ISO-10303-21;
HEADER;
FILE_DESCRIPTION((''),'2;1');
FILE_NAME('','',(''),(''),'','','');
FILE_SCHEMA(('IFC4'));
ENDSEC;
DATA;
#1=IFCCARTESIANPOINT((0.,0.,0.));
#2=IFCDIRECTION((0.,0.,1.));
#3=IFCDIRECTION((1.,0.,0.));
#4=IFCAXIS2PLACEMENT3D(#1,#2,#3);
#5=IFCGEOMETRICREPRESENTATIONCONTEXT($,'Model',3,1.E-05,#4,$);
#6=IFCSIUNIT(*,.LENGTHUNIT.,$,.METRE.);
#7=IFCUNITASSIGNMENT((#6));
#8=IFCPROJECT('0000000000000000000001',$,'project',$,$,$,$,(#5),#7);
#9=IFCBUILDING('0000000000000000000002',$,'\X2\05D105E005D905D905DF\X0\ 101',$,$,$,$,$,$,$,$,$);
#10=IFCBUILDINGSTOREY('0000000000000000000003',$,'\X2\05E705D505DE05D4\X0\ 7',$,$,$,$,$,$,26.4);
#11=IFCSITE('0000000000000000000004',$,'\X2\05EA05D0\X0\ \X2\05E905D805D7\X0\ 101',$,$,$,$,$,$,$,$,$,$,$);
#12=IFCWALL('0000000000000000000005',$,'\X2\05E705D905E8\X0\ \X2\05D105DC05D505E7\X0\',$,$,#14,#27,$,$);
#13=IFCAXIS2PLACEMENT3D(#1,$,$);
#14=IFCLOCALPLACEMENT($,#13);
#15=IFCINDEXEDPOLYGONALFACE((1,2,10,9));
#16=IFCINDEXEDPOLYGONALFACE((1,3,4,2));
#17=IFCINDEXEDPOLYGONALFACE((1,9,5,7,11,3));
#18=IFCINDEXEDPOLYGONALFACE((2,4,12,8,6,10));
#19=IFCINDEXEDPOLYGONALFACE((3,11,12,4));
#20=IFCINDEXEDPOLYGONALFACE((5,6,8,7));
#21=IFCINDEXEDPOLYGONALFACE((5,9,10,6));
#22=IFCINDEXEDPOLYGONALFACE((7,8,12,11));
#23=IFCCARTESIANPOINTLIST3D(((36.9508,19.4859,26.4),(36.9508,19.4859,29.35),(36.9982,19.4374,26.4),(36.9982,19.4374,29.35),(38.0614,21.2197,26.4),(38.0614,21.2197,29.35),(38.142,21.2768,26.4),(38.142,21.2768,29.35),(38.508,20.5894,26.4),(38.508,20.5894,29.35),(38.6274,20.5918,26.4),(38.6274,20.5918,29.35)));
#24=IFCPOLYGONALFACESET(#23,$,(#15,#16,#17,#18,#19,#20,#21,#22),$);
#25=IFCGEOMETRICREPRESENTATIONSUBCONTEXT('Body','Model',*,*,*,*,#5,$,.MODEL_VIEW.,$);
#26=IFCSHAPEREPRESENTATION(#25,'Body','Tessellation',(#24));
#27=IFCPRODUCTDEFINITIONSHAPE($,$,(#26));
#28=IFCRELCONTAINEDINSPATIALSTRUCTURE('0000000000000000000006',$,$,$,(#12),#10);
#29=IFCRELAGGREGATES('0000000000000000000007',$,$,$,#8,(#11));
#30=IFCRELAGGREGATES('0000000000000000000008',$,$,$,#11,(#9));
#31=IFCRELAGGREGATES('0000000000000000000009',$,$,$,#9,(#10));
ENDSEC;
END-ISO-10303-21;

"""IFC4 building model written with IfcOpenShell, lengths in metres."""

from ifc_helpers import new_model, si_unit, frame, origin_with_axes, context, subcontext, project, spatial, polyline, outline, extrude, element, save


model = new_model("IFC4")

# Units and contexts
model_context = context("Model", 3, precision=1e-05, world=origin_with_axes())
body_context = subcontext(model_context, "Body", "Model", "MODEL_VIEW")
ifc_project = project(units=[si_unit("LENGTHUNIT", "METRE")], contexts=[model_context])

# Site, building, storey
site = spatial("IfcSite", under=ifc_project, Name="תא שטח 101")
building = spatial("IfcBuilding", under=site, Name="בניין 101")
storey = spatial("IfcBuildingStorey", under=building, Name="קומה 7", Elevation=26.4)

# Wall
element("IfcWall", 1, inside=storey, Name="קיר בלוק", context=body_context, shape_type="SweptSolid", body=[
    extrude(outline(polyline([(36.9982, 19.4374), (38.6274, 20.5918), (38.142, 21.2768), (38.0614, 21.2197), (38.508, 20.5894), (36.9508, 19.4859), (36.9982, 19.4374)])), frame((0.0, 0.0, 26.4)), (0.0, 0.0, 1.0), 2.95),
])

save(model, "model.ifc")
